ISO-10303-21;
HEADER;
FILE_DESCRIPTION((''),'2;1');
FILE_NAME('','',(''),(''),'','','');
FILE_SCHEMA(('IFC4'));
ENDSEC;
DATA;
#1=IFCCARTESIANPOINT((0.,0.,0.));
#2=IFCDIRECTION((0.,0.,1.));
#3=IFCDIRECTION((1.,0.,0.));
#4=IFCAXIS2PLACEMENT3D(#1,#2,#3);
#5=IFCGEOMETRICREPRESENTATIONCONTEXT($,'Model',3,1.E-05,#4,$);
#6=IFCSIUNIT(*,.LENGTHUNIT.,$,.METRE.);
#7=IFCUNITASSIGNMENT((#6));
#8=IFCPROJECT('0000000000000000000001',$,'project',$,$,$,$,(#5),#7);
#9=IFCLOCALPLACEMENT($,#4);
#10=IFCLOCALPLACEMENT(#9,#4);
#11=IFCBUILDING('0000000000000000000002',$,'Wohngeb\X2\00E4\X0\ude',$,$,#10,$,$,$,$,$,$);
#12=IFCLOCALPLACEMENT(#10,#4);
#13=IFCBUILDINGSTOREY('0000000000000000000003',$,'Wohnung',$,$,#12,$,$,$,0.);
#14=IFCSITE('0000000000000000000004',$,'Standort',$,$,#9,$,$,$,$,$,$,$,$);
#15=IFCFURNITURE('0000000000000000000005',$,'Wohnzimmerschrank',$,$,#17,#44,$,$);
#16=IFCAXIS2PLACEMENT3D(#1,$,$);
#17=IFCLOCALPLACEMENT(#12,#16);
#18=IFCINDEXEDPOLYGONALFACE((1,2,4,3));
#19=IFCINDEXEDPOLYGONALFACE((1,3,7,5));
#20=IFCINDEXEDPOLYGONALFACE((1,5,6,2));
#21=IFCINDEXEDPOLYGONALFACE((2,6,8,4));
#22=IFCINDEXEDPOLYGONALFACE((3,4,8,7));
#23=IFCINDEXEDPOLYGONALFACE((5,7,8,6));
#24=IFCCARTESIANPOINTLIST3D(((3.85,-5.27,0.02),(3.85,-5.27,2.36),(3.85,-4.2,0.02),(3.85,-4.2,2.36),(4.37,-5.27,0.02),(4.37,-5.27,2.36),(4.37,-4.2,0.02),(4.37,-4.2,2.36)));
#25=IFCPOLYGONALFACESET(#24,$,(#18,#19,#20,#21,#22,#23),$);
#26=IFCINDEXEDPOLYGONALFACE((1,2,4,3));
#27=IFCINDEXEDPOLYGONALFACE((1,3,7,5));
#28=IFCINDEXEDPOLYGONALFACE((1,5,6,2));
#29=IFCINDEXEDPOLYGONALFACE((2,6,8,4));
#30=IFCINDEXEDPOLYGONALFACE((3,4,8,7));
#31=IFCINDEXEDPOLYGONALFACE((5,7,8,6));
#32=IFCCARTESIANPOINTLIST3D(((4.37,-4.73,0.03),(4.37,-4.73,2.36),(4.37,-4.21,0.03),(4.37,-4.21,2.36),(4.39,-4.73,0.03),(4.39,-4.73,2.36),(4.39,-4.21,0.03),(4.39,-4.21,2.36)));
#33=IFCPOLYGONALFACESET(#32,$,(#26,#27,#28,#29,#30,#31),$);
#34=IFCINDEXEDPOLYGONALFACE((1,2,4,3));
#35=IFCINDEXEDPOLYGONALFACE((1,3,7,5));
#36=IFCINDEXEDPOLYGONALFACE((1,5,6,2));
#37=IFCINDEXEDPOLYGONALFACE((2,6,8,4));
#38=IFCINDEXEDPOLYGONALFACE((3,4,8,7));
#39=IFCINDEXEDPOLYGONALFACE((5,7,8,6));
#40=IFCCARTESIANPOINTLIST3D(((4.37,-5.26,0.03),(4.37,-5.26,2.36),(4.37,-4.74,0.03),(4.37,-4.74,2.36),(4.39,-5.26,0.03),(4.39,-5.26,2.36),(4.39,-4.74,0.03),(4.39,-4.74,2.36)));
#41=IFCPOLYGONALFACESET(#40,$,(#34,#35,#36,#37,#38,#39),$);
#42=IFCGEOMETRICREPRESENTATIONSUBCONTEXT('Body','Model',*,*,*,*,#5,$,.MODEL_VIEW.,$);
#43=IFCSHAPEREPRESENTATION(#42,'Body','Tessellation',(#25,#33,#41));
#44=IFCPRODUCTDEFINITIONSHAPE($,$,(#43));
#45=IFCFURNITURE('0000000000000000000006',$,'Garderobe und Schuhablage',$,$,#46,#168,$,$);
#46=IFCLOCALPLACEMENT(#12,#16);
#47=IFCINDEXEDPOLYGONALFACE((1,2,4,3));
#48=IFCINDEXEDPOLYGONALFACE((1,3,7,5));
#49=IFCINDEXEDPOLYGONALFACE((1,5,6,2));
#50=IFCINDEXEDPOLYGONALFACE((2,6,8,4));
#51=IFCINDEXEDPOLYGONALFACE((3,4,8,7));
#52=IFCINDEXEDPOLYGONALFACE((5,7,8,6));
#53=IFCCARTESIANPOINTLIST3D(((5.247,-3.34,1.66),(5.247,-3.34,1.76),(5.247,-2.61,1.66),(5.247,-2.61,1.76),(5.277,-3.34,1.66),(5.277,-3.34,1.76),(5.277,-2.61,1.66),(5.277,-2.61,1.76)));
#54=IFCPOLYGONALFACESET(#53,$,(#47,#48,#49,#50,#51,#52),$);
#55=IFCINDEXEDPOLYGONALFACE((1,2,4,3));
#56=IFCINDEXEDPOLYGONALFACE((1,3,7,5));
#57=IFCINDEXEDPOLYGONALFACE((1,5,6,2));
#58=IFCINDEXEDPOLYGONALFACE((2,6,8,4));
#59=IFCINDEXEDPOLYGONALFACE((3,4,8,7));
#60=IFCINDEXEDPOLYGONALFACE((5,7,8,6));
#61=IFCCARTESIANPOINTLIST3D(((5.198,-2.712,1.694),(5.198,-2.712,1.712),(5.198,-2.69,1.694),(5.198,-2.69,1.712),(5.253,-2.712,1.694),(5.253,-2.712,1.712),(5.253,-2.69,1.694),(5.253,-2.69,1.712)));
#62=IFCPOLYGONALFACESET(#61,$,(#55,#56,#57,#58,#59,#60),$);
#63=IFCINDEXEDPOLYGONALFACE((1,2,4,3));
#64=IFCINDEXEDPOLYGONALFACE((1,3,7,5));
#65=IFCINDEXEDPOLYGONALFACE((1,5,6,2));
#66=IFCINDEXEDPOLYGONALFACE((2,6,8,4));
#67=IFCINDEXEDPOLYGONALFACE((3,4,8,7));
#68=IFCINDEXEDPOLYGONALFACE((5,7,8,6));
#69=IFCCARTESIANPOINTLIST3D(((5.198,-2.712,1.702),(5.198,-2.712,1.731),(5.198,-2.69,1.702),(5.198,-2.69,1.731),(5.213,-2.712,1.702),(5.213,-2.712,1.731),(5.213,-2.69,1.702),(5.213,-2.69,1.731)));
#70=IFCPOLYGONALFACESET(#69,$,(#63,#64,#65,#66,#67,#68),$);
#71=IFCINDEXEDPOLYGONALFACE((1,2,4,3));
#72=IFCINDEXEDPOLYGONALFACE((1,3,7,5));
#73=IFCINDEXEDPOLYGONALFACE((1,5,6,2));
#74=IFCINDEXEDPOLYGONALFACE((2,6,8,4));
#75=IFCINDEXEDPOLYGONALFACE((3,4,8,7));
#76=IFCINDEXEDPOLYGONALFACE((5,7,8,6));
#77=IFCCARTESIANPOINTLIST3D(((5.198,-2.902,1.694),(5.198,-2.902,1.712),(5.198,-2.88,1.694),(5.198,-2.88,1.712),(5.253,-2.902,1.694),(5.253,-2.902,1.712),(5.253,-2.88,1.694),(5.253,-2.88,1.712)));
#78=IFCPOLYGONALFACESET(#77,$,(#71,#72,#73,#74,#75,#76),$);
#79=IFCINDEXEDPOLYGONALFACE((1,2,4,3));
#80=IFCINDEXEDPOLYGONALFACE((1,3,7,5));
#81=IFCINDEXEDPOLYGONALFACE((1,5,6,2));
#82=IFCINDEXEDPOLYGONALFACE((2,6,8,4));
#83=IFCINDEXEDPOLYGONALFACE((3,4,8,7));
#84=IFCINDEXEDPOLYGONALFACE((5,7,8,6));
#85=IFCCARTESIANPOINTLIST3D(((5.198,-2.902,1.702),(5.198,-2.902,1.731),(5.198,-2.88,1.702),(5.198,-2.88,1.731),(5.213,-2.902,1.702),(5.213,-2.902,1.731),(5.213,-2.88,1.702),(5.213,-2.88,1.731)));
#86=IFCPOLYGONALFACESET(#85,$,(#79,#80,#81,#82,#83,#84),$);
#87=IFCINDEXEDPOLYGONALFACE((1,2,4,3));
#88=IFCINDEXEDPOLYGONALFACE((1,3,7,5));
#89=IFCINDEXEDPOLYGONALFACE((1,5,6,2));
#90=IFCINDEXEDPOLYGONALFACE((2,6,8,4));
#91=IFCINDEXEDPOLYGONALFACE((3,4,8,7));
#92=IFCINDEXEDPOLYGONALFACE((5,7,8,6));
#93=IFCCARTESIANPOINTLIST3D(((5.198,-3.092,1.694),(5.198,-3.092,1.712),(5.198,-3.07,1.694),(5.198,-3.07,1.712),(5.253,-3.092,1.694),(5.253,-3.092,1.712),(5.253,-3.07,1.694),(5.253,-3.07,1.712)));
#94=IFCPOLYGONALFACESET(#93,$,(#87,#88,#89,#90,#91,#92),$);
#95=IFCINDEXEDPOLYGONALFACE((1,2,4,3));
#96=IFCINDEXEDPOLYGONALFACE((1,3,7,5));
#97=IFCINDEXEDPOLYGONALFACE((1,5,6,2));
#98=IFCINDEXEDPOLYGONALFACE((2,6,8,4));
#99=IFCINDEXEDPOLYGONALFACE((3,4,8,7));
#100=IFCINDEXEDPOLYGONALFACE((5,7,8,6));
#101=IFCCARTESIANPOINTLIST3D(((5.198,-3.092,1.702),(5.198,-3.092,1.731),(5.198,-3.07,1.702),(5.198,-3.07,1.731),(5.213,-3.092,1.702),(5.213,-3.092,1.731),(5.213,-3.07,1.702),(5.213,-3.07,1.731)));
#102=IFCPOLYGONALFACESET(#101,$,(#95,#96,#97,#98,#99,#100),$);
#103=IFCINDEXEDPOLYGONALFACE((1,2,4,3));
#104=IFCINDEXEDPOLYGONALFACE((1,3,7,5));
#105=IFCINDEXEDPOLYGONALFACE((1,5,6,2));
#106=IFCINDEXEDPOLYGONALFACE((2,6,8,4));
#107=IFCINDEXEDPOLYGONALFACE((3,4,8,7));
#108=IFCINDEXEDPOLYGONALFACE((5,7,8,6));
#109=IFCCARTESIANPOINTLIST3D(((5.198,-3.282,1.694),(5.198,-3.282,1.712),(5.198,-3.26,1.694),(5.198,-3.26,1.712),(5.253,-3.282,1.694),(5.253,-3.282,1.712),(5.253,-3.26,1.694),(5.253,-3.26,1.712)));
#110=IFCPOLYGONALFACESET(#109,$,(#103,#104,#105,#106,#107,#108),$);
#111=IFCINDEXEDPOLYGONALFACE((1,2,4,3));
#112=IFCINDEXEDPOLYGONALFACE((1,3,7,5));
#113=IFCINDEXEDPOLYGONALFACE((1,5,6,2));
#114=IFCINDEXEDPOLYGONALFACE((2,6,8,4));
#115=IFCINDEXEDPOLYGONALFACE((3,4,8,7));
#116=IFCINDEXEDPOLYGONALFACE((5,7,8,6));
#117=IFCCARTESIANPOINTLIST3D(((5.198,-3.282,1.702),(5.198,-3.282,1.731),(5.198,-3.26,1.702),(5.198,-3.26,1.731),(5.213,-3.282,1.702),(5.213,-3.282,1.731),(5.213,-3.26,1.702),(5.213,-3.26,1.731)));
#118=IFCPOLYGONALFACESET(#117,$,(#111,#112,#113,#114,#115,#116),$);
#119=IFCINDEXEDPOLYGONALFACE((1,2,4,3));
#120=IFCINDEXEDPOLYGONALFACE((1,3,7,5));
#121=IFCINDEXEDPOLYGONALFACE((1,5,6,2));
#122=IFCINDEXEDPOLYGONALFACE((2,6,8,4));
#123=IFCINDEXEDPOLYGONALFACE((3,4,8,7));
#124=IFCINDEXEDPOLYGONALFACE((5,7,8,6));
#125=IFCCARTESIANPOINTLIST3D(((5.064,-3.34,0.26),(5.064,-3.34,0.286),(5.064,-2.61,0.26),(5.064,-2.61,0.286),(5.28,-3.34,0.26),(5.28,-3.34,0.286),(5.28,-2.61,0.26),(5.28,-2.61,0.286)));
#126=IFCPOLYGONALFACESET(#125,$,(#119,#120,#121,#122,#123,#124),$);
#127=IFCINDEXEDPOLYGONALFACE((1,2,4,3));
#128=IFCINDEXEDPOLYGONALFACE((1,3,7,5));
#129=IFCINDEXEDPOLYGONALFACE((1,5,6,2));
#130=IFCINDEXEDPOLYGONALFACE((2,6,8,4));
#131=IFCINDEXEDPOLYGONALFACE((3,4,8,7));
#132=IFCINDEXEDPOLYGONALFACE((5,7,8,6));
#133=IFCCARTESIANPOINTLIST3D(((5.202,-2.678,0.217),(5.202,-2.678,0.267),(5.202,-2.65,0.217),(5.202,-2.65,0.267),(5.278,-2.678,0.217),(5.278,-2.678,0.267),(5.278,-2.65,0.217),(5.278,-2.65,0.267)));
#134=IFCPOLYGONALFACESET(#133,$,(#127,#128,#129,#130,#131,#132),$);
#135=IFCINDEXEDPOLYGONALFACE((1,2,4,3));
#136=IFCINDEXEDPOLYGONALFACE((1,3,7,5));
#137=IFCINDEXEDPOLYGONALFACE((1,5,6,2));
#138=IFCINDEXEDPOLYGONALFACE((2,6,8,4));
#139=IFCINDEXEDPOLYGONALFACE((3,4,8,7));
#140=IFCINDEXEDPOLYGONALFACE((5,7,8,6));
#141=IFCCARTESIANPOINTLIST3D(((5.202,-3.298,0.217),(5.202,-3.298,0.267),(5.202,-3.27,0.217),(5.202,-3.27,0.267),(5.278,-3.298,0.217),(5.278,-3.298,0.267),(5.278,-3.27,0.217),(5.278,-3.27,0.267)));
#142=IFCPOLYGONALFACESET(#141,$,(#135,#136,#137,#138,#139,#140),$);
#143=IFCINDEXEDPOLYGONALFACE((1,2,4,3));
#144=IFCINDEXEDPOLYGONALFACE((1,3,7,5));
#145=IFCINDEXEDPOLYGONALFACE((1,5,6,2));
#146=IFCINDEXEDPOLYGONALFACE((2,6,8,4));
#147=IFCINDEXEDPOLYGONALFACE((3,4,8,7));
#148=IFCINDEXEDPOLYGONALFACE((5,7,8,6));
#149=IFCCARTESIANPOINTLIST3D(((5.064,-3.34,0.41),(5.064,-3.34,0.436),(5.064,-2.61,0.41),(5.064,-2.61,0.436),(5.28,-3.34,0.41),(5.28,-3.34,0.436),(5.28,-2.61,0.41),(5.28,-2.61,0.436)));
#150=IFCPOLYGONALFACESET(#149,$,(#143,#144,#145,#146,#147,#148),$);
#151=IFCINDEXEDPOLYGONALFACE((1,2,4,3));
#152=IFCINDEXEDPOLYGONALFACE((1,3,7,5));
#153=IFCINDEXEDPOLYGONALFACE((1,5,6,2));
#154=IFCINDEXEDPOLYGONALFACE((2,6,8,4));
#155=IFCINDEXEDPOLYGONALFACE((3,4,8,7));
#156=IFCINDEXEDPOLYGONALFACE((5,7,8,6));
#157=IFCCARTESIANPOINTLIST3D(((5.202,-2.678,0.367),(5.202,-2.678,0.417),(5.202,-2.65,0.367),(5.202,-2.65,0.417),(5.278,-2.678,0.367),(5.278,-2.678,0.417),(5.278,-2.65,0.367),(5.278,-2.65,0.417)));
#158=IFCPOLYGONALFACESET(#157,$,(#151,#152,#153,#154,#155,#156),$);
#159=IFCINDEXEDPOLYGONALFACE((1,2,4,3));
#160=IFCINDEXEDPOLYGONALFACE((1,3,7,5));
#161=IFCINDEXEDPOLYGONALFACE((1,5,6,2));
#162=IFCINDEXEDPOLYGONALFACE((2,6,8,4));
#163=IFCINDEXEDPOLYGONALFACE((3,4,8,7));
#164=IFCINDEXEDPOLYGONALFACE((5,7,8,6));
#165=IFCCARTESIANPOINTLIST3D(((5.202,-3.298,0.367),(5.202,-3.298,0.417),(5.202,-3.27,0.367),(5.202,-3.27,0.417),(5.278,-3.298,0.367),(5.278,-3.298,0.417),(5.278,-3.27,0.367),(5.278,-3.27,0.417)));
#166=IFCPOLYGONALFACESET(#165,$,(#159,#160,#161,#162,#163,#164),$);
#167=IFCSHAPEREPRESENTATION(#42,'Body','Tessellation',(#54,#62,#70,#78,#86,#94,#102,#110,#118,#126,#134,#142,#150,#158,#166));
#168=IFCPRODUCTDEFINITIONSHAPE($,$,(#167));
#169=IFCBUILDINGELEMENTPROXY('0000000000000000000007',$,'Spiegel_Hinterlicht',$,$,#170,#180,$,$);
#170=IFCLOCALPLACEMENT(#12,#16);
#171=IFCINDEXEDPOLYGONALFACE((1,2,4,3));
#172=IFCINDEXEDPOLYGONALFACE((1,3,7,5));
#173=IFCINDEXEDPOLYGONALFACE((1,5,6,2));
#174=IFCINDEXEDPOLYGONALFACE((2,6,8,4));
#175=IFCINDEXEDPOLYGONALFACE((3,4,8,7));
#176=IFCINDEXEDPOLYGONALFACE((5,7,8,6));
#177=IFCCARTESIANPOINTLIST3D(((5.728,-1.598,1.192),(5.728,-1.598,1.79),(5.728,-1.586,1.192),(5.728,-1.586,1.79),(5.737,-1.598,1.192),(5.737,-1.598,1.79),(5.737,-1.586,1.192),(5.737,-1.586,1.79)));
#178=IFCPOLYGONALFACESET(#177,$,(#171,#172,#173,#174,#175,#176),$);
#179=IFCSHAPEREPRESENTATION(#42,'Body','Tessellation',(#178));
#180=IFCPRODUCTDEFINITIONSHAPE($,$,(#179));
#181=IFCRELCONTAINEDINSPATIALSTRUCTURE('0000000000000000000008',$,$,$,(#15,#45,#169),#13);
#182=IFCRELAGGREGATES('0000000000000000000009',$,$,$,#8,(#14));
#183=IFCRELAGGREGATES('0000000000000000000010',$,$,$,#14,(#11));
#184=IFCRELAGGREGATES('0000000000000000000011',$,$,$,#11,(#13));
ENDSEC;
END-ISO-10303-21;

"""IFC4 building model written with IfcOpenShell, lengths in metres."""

from ifc_helpers import new_model, si_unit, frame, origin, origin_with_axes, place, context, subcontext, project, spatial, polyline, outline, extrude, element, save


model = new_model("IFC4")

# Units and contexts
model_context = context("Model", 3, precision=1e-05, world=origin_with_axes())
body_context = subcontext(model_context, "Body", "Model", "MODEL_VIEW")
ifc_project = project(units=[si_unit("LENGTHUNIT", "METRE")], contexts=[model_context])

# Site, building, storey
site_placement = place(None, origin_with_axes())
site = spatial("IfcSite", under=ifc_project, at=site_placement, Name="Standort")
building_placement = place(site_placement, origin_with_axes())
building = spatial("IfcBuilding", under=site, at=building_placement, Name="Wohngebäude")
storey_placement = place(building_placement, origin_with_axes())
storey = spatial("IfcBuildingStorey", under=building, at=storey_placement, Name="Wohnung", Elevation=0.0)

# Furniture
furniture_1_placement = place(storey_placement, frame((3.85, -4.2, 0.02), z_axis=(0.0, 0.0, 1.0), x_axis=(1.0, 0.0, 0.0)))
element("IfcFurniture", 1, at=furniture_1_placement, inside=storey, Name="Wohnzimmerschrank", context=body_context, shape_type="SweptSolid", body=[
    extrude(outline(polyline([(0.0, 0.0), (0.0, -1.07), (0.52, -1.07), (0.52, 0.0), (0.0, 0.0)])), origin(), (0.0, 0.0, 1.0), 2.34),
    extrude(outline(polyline([(0.52, -0.01), (0.52, -0.53), (0.54, -0.53), (0.54, -0.01), (0.52, -0.01)])), frame((0.0, 0.0, 0.01)), (0.0, 0.0, 1.0), 2.33),
    extrude(outline(polyline([(0.52, -0.54), (0.52, -1.06), (0.54, -1.06), (0.54, -0.54), (0.52, -0.54)])), frame((0.0, 0.0, 0.01)), (0.0, 0.0, 1.0), 2.33),
])
furniture_2_placement = place(storey_placement, frame((5.064, -2.61, 0.217), z_axis=(0.0, 0.0, 1.0), x_axis=(1.0, 0.0, 0.0)))
element("IfcFurniture", 2, at=furniture_2_placement, inside=storey, Name="Garderobe und Schuhablage", context=body_context, shape_type="SweptSolid", body=[
    extrude(outline(polyline([(0.183, 0.0), (0.183, -0.73), (0.213, -0.73), (0.213, 0.0), (0.183, 0.0)])), frame((0.0, 0.0, 1.443)), (0.0, 0.0, 1.0), 0.1),
    extrude(outline(polyline([(0.134, -0.08), (0.134, -0.102), (0.189, -0.102), (0.189, -0.08), (0.134, -0.08)])), frame((0.0, 0.0, 1.477)), (0.0, 0.0, 1.0), 0.018),
    extrude(outline(polyline([(0.134, -0.08), (0.134, -0.102), (0.149, -0.102), (0.149, -0.08), (0.134, -0.08)])), frame((0.0, 0.0, 1.485)), (0.0, 0.0, 1.0), 0.029),
    extrude(outline(polyline([(0.134, -0.27), (0.134, -0.292), (0.189, -0.292), (0.189, -0.27), (0.134, -0.27)])), frame((0.0, 0.0, 1.477)), (0.0, 0.0, 1.0), 0.018),
    extrude(outline(polyline([(0.134, -0.27), (0.134, -0.292), (0.149, -0.292), (0.149, -0.27), (0.134, -0.27)])), frame((0.0, 0.0, 1.485)), (0.0, 0.0, 1.0), 0.029),
    extrude(outline(polyline([(0.134, -0.46), (0.134, -0.482), (0.189, -0.482), (0.189, -0.46), (0.134, -0.46)])), frame((0.0, 0.0, 1.477)), (0.0, 0.0, 1.0), 0.018),
    extrude(outline(polyline([(0.134, -0.46), (0.134, -0.482), (0.149, -0.482), (0.149, -0.46), (0.134, -0.46)])), frame((0.0, 0.0, 1.485)), (0.0, 0.0, 1.0), 0.029),
    extrude(outline(polyline([(0.134, -0.65), (0.134, -0.672), (0.189, -0.672), (0.189, -0.65), (0.134, -0.65)])), frame((0.0, 0.0, 1.477)), (0.0, 0.0, 1.0), 0.018),
    extrude(outline(polyline([(0.134, -0.65), (0.134, -0.672), (0.149, -0.672), (0.149, -0.65), (0.134, -0.65)])), frame((0.0, 0.0, 1.485)), (0.0, 0.0, 1.0), 0.029),
    extrude(outline(polyline([(0.0, 0.0), (0.0, -0.73), (0.216, -0.73), (0.216, 0.0), (0.0, 0.0)])), frame((0.0, 0.0, 0.043)), (0.0, 0.0, 1.0), 0.026),
    extrude(outline(polyline([(0.138, -0.04), (0.138, -0.068), (0.214, -0.068), (0.214, -0.04), (0.138, -0.04)])), origin(), (0.0, 0.0, 1.0), 0.05),
    extrude(outline(polyline([(0.138, -0.66), (0.138, -0.688), (0.214, -0.688), (0.214, -0.66), (0.138, -0.66)])), origin(), (0.0, 0.0, 1.0), 0.05),
    extrude(outline(polyline([(0.0, 0.0), (0.0, -0.73), (0.216, -0.73), (0.216, 0.0), (0.0, 0.0)])), frame((0.0, 0.0, 0.193)), (0.0, 0.0, 1.0), 0.026),
    extrude(outline(polyline([(0.138, -0.04), (0.138, -0.068), (0.214, -0.068), (0.214, -0.04), (0.138, -0.04)])), frame((0.0, 0.0, 0.15)), (0.0, 0.0, 1.0), 0.05),
    extrude(outline(polyline([(0.138, -0.66), (0.138, -0.688), (0.214, -0.688), (0.214, -0.66), (0.138, -0.66)])), frame((0.0, 0.0, 0.15)), (0.0, 0.0, 1.0), 0.05),
])

# Building element proxy
proxy_placement = place(storey_placement, frame((5.728, -1.586, 1.192), z_axis=(0.0, 0.0, 1.0), x_axis=(1.0, 0.0, 0.0)))
element("IfcBuildingElementProxy", 3, at=proxy_placement, inside=storey, Name="Spiegel_Hinterlicht", context=body_context, shape_type="SweptSolid", body=[
    extrude(outline(polyline([(0.0, 0.0), (0.0, -0.012), (0.009, -0.012), (0.009, 0.0), (0.0, 0.0)])), origin(), (0.0, 0.0, 1.0), 0.598),
])

save(model, "model.ifc")
